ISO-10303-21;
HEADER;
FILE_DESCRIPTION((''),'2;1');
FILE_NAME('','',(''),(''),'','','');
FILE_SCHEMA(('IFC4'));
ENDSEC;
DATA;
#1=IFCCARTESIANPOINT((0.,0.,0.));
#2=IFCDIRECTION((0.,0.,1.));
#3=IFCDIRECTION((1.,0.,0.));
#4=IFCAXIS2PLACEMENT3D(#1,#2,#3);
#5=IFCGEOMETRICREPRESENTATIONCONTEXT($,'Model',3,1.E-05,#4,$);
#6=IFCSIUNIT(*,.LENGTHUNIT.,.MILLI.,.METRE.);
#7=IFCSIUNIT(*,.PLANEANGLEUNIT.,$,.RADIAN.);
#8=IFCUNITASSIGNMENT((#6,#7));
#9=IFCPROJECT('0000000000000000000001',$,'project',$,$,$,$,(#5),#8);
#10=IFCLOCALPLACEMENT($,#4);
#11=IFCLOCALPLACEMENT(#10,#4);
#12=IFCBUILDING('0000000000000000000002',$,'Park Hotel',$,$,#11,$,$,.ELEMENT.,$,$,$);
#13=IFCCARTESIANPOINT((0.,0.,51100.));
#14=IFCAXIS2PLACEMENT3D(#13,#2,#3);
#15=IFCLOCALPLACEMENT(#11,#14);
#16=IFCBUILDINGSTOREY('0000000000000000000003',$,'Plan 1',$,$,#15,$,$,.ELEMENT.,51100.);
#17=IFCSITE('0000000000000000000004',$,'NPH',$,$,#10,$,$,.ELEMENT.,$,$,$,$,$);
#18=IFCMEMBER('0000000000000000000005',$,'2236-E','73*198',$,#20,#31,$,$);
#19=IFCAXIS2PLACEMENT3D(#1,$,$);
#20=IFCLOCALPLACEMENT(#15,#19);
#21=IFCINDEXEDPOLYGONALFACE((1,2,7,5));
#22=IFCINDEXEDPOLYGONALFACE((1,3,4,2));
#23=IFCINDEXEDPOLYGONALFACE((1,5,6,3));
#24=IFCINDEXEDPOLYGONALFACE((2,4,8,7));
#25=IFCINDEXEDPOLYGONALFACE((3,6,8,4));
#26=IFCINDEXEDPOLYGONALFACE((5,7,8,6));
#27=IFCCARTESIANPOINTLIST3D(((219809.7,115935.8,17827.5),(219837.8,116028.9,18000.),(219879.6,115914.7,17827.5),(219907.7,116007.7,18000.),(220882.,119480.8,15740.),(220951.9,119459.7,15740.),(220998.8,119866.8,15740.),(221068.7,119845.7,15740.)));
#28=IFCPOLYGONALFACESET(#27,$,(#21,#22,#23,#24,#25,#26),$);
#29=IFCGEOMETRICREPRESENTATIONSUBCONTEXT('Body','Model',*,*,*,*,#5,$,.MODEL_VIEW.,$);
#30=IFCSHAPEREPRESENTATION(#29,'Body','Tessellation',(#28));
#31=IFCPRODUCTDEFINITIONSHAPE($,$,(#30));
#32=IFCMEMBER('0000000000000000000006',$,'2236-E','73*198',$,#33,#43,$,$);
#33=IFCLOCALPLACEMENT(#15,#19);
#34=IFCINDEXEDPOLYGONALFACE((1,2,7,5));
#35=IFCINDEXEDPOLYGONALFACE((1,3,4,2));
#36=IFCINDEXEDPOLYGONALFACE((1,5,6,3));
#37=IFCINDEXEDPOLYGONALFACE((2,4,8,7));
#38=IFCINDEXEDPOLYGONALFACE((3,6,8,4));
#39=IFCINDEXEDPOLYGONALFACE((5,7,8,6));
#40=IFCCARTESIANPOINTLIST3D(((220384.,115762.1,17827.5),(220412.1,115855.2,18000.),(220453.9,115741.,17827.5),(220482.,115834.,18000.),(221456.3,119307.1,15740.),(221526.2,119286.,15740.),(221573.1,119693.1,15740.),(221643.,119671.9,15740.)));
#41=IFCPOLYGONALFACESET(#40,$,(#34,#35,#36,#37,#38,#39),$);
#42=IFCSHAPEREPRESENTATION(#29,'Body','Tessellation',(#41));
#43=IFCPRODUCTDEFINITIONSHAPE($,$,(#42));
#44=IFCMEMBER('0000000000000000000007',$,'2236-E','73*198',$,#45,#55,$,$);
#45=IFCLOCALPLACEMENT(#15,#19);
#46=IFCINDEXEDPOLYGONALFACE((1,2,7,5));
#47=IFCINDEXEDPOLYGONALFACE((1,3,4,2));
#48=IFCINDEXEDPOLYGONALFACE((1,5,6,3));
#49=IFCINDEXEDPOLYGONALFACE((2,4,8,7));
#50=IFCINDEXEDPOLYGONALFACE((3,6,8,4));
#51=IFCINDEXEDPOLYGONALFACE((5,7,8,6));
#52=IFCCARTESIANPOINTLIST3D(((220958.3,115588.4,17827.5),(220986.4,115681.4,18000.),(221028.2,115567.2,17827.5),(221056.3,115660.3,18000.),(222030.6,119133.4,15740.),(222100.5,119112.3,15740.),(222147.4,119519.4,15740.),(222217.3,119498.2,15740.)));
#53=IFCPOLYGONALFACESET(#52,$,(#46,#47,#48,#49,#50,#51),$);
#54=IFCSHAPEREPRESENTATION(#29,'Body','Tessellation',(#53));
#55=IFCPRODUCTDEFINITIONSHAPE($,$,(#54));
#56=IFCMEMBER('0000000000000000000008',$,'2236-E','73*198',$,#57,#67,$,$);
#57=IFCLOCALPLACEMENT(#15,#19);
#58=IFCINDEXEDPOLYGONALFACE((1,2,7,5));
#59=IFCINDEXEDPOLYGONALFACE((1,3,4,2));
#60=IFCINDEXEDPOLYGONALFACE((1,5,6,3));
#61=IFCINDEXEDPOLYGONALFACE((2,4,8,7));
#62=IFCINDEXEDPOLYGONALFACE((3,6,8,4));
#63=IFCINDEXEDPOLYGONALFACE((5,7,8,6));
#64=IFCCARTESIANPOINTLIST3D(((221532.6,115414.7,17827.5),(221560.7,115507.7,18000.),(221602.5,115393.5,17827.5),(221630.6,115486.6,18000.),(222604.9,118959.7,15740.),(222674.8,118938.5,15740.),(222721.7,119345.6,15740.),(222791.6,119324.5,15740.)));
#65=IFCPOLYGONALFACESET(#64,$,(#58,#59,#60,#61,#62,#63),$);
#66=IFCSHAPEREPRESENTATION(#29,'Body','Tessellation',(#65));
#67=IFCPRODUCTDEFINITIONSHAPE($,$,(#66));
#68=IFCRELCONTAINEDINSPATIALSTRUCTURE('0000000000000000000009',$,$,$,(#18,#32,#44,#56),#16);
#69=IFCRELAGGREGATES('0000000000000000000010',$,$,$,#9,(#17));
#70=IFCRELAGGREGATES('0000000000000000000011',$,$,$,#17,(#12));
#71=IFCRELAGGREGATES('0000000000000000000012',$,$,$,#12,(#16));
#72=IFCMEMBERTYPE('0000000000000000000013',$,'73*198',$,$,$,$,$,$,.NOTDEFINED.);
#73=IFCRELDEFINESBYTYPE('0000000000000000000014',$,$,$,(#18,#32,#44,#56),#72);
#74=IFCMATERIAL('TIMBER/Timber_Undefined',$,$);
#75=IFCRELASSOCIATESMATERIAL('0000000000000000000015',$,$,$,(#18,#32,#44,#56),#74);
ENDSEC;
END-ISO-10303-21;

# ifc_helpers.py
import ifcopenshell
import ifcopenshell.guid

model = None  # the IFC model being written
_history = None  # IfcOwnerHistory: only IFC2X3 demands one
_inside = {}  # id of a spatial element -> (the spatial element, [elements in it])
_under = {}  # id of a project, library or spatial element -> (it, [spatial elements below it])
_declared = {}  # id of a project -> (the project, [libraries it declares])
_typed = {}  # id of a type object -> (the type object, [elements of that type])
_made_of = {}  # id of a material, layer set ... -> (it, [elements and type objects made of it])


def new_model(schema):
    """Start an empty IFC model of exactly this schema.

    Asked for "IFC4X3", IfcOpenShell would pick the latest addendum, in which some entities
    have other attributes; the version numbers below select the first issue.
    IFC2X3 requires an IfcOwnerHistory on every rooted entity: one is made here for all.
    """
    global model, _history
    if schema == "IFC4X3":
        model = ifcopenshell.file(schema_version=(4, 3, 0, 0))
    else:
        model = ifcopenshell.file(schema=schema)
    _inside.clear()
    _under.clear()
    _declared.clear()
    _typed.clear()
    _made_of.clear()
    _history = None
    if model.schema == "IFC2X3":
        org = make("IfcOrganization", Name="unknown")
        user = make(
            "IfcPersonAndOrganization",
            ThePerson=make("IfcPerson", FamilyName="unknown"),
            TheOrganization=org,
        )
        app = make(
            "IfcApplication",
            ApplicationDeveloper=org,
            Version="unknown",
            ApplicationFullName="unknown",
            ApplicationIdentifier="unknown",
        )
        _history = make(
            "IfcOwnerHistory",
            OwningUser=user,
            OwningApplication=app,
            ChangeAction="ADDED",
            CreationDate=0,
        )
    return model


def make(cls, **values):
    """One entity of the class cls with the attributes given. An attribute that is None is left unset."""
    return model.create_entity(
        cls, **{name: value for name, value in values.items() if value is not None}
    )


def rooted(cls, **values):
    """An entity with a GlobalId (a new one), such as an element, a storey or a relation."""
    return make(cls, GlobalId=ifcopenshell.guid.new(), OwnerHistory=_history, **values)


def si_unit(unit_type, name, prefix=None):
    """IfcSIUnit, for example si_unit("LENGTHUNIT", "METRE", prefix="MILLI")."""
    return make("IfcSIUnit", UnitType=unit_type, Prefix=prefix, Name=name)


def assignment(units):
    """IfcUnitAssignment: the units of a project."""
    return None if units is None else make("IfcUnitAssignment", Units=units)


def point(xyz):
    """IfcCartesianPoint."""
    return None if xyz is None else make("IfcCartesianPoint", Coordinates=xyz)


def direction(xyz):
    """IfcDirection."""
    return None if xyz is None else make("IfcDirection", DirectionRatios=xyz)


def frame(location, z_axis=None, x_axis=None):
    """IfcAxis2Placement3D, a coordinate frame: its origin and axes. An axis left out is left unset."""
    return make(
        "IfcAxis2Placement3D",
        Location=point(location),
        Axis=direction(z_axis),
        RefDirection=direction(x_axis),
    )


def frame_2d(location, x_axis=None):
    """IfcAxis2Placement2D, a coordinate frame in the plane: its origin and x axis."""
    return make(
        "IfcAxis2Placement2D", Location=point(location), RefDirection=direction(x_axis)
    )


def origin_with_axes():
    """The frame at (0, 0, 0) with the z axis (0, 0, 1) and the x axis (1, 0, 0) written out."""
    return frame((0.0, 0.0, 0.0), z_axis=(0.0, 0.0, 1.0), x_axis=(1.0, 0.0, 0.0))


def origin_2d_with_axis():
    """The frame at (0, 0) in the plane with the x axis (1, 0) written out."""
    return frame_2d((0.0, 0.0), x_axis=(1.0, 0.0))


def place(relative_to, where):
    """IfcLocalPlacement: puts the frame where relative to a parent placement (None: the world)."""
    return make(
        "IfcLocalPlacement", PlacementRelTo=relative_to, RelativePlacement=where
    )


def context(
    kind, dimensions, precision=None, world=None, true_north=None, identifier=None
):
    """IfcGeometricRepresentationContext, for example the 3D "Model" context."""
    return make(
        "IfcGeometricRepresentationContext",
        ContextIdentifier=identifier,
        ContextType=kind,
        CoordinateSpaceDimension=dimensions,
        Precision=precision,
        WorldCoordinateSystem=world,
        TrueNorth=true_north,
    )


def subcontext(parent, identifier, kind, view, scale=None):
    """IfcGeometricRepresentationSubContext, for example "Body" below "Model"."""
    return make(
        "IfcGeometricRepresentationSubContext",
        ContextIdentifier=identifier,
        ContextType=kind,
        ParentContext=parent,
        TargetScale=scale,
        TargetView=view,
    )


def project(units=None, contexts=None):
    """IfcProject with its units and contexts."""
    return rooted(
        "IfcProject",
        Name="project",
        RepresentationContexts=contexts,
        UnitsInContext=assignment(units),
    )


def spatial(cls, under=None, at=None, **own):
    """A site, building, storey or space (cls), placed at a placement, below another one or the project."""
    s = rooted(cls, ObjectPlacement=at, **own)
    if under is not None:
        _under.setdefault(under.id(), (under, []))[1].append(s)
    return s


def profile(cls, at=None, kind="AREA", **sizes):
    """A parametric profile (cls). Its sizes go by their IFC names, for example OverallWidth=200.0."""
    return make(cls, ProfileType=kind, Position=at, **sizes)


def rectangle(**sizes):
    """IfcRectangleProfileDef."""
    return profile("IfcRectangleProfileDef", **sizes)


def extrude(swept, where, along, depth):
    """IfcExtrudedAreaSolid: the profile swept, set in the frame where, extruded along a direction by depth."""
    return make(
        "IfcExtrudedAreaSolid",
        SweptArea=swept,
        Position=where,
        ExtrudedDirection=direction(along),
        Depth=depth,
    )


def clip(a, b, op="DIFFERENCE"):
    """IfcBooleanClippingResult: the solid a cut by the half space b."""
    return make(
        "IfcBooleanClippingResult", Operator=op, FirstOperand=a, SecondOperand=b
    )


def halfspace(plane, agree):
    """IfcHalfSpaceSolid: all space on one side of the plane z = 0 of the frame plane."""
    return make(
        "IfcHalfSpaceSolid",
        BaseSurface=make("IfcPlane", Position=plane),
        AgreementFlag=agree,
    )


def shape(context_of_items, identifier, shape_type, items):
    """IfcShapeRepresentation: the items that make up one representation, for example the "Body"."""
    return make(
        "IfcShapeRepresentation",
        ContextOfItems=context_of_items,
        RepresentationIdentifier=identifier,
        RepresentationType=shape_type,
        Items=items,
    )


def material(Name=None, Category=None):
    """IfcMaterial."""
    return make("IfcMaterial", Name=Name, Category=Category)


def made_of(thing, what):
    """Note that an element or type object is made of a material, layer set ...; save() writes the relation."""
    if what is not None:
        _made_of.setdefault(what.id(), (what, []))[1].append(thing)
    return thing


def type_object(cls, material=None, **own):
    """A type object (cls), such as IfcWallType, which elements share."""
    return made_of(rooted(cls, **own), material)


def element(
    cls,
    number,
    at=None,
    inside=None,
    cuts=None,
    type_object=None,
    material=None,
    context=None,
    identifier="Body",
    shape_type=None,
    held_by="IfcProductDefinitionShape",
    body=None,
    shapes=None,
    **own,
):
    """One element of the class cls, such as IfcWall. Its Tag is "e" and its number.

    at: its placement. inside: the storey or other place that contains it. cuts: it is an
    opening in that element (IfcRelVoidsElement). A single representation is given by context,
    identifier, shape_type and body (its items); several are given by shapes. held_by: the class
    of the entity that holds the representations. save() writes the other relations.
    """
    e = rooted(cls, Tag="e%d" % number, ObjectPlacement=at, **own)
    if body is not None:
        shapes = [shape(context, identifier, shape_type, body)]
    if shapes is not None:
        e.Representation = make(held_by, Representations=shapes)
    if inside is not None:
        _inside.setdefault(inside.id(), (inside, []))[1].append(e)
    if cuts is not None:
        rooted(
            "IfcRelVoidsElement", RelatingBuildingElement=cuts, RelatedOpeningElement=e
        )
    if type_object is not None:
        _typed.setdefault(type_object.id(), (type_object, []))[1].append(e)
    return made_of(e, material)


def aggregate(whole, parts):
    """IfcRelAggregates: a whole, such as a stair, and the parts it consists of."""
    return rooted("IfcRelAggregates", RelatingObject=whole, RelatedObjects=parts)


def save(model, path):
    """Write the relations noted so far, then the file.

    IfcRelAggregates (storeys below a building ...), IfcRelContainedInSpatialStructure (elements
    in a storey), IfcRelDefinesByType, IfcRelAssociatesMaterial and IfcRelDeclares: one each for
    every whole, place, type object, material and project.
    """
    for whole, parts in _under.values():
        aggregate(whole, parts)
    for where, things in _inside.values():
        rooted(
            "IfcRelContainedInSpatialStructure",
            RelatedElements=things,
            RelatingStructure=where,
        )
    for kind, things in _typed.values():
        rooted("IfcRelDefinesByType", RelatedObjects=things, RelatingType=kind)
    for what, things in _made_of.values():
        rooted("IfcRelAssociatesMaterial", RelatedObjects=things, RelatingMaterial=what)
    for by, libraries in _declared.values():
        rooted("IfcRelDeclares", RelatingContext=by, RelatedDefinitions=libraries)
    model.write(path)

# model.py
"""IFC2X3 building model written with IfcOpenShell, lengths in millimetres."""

from ifc_helpers import new_model, si_unit, frame, origin_with_axes, origin_2d_with_axis, place, context, subcontext, project, spatial, rectangle, extrude, clip, halfspace, material, type_object, element, save


model = new_model("IFC2X3")

# Units and contexts
model_context = context("Model", 3, precision=1e-05, world=origin_with_axes())
body_context = subcontext(model_context, "Body", "Model", "MODEL_VIEW")
ifc_project = project(units=[si_unit("LENGTHUNIT", "METRE", prefix="MILLI"), si_unit("PLANEANGLEUNIT", "RADIAN")], contexts=[model_context])

# Site, building, storey
site_placement = place(None, origin_with_axes())
site = spatial("IfcSite", under=ifc_project, at=site_placement, Name="NPH", CompositionType="ELEMENT")
building_placement = place(site_placement, origin_with_axes())
building = spatial("IfcBuilding", under=site, at=building_placement, Name="Park Hotel", CompositionType="ELEMENT")
storey_placement = place(building_placement, frame((0.0, 0.0, 51100.0), z_axis=(0.0, 0.0, 1.0), x_axis=(1.0, 0.0, 0.0)))
storey = spatial("IfcBuildingStorey", under=building, at=storey_placement, Name="Plan 1", CompositionType="ELEMENT", Elevation=51100.0)

# Shared definitions
ifc_material = material(Name="TIMBER/Timber_Undefined")

# Members
member_type = type_object("IfcMemberType", Name="73*198", PredefinedType="NOTDEFINED")
for number, where, z_axis, x_axis, name in (
    (1, (219858.7, 115971.8, 17913.8), (-0.957167, 0.289538, 0.0), (0.252232, 0.833838, -0.491013), "2236-E"),
    (2, (220433.0, 115798.1, 17913.8), (-0.957167, 0.289538, 0.0), (0.252232, 0.833838, -0.491013), "2236-E"),
    (3, (221007.3, 115624.3, 17913.8), (-0.957167, 0.289538, 0.0), (0.252232, 0.833838, -0.491013), "2236-E"),
    (4, (221581.6, 115450.6, 17913.8), (-0.957167, 0.289538, 0.0), (0.252232, 0.833838, -0.491013), "2236-E"),
):
    element("IfcMember", number, at=place(storey_placement, frame(where, z_axis=z_axis, x_axis=x_axis)), inside=storey, type_object=member_type, material=ifc_material, Name=name, Description="73*198", context=body_context, shape_type="Clipping", body=[
        clip(extrude(rectangle(XDim=198.0, YDim=73.0, at=origin_2d_with_axis()), frame((9470.2, 0.0, 0.0), z_axis=(-1.0, 0.0, 0.0), x_axis=(0.0, -1.0, 0.0)), (0.0, 0.0, 1.0), 9470.2), halfspace(frame((4746.2, -179.9, -36.5), z_axis=(0.491013, 0.871152, 0.0), x_axis=(0.0, 0.0, 1.0)), False)),
    ])

save(model, "model.ifc")
